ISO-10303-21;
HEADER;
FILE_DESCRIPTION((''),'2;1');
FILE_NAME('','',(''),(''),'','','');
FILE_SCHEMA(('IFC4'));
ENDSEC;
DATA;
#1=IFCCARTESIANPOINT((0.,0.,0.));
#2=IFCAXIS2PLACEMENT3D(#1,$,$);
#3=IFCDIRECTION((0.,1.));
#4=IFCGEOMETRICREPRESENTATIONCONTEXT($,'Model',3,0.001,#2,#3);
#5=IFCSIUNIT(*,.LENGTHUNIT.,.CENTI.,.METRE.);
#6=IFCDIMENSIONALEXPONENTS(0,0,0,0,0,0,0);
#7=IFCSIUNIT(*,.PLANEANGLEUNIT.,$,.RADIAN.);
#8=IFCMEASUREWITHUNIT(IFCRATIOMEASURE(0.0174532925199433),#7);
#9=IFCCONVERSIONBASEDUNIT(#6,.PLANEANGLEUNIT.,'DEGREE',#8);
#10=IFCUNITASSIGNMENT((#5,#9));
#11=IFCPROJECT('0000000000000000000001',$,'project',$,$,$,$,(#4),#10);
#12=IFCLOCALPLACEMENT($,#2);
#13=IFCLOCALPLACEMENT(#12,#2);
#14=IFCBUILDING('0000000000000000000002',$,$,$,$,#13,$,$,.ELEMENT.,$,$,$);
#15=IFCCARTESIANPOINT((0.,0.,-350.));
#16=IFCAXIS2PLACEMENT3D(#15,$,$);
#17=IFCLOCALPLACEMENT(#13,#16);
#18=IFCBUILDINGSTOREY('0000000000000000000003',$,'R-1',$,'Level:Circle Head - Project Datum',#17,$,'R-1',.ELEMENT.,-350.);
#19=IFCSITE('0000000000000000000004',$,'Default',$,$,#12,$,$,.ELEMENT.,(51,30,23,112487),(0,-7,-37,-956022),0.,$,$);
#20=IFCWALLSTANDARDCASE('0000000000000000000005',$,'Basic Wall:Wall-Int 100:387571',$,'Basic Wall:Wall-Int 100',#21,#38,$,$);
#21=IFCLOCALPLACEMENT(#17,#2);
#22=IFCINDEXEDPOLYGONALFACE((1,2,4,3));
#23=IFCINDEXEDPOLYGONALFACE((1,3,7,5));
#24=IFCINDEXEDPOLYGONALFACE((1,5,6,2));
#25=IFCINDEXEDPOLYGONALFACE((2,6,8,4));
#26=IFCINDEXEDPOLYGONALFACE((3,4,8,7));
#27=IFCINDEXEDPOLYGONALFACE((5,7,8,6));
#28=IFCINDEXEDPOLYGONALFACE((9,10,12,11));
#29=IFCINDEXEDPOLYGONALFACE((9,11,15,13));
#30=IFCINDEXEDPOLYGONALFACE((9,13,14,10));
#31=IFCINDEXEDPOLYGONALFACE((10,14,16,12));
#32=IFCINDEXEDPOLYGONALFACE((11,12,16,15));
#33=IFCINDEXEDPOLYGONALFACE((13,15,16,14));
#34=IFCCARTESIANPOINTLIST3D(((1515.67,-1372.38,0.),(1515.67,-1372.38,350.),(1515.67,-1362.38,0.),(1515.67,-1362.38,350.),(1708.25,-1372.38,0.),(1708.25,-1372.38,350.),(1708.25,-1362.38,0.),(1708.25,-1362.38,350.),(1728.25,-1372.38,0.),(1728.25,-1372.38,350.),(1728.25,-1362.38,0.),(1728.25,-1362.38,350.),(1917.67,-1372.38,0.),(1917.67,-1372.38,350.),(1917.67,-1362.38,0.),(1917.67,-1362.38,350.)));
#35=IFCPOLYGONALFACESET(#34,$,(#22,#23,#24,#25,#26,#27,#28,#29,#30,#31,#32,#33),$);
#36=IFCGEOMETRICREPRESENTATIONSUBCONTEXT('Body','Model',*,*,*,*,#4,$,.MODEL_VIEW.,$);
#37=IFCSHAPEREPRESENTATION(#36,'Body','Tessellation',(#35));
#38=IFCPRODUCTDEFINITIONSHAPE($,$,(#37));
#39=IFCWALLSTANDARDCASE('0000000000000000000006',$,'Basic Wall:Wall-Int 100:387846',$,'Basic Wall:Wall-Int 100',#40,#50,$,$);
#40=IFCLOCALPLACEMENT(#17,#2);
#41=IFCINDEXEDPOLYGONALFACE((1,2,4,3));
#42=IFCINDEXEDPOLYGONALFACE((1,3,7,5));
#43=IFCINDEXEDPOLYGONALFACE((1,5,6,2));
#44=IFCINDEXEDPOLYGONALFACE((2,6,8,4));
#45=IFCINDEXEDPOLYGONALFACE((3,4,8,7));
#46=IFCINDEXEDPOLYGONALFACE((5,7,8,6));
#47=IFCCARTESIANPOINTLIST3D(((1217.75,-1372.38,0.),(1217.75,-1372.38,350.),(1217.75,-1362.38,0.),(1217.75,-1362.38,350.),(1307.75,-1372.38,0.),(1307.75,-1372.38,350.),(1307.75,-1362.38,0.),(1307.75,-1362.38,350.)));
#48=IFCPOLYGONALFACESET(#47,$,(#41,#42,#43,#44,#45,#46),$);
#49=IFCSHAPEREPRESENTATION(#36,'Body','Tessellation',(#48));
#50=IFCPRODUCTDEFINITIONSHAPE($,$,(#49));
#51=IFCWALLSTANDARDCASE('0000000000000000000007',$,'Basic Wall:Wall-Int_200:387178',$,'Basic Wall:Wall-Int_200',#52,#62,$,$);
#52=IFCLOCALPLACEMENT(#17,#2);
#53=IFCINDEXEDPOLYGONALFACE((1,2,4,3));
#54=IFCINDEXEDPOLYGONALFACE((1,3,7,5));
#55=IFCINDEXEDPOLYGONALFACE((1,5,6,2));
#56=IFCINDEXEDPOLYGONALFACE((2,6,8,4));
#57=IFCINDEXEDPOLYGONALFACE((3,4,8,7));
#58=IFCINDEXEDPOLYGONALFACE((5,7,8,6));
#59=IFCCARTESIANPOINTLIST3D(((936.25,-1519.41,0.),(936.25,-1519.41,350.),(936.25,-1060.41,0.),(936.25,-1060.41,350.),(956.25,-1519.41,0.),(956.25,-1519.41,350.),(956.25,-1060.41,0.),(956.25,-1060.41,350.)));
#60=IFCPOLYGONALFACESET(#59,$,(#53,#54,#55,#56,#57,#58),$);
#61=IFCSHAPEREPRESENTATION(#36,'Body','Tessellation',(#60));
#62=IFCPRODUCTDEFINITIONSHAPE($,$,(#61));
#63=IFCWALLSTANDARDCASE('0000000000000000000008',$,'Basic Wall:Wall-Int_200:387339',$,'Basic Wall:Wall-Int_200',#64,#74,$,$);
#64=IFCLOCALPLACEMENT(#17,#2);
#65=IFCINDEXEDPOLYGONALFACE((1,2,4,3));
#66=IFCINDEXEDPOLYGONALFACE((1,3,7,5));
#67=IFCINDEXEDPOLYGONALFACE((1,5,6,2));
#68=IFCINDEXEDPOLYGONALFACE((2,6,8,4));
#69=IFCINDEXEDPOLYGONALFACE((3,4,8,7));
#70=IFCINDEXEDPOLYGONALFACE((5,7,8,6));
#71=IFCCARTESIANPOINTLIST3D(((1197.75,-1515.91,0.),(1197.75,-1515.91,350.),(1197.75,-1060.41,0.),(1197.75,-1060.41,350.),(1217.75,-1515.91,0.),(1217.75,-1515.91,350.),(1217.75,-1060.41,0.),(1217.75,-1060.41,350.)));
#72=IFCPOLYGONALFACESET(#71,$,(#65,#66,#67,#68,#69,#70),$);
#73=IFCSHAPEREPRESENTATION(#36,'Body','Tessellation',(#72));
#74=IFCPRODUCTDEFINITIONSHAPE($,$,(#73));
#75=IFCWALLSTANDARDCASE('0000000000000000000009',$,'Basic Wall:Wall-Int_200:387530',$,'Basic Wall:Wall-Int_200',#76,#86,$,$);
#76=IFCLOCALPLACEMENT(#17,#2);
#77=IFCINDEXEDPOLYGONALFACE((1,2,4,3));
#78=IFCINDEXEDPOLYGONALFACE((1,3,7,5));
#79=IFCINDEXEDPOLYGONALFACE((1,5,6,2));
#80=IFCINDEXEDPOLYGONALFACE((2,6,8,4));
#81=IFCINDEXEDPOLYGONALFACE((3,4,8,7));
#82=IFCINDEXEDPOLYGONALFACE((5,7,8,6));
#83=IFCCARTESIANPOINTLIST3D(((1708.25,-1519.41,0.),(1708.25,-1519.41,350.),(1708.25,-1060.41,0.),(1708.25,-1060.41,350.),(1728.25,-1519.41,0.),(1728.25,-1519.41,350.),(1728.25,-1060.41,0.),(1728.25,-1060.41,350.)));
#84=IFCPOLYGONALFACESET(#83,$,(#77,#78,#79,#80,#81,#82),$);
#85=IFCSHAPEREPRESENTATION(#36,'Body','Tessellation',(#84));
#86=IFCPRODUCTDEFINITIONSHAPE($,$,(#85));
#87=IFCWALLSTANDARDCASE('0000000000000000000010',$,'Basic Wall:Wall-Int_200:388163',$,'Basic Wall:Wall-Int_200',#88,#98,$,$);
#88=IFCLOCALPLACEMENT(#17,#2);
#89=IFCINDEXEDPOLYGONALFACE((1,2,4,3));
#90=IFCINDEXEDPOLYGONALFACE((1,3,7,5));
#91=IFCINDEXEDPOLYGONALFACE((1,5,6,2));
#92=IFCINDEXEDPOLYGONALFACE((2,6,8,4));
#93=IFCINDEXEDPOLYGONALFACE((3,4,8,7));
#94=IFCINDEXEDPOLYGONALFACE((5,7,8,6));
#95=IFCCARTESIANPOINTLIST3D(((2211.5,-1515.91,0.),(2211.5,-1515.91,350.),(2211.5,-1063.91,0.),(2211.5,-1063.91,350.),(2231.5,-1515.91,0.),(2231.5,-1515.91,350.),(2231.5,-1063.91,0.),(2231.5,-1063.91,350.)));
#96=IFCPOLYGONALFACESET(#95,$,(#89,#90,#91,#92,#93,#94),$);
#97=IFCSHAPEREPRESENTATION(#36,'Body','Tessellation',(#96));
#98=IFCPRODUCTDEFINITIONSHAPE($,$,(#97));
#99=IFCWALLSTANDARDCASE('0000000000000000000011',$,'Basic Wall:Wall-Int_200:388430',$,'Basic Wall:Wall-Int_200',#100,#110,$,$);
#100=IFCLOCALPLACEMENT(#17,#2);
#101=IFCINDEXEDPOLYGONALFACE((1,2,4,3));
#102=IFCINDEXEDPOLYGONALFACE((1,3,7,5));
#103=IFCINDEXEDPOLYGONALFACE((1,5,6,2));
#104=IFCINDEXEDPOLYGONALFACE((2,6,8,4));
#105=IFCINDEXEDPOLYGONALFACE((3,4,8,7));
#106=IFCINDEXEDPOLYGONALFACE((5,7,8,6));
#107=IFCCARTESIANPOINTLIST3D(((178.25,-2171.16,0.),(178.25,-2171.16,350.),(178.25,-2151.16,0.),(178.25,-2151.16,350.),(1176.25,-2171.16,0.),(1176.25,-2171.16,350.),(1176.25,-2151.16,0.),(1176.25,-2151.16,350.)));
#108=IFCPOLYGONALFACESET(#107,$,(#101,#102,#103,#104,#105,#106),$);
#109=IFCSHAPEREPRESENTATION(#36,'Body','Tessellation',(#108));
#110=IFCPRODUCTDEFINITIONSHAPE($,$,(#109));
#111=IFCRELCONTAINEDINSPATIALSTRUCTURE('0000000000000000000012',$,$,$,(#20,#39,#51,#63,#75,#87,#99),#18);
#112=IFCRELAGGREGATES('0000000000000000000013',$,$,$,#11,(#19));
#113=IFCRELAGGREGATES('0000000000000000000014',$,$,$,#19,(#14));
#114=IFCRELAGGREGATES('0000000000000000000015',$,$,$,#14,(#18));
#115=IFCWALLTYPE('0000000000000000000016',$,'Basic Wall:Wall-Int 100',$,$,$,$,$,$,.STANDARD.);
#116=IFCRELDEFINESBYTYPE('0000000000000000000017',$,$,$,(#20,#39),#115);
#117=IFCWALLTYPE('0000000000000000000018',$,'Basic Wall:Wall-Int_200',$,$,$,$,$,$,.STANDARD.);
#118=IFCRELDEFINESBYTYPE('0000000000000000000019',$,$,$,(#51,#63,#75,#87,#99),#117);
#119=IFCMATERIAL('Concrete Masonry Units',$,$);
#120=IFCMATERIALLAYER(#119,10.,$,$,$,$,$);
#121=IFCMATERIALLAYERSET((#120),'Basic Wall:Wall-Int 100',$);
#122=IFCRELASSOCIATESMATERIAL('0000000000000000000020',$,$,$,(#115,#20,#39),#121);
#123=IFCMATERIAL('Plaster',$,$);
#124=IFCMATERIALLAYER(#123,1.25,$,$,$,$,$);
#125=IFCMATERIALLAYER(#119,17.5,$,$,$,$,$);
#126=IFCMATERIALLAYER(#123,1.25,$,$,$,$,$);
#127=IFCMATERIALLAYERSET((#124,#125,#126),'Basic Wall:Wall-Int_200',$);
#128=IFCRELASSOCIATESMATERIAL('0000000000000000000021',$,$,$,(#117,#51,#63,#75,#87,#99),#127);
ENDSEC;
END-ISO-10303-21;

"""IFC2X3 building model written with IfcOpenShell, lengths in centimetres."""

from ifc_helpers import new_model, entity, si_unit, converted_unit, direction, frame, frame_2d, origin, place, context, subcontext, project, spatial, rectangle, extrude, material, layer, layer_set, layer_usage, type_object, element, save


model = new_model("IFC2X3")

# Units and contexts
model_context = context("Model", 3, precision=0.001, world=origin(), true_north=direction((0.0, 1.0)))
body_context = subcontext(model_context, "Body", "Model", "MODEL_VIEW")
ifc_project = project(units=[si_unit("LENGTHUNIT", "METRE", prefix="CENTI"), converted_unit("PLANEANGLEUNIT", "DEGREE", entity("IfcRatioMeasure", 0.0174532925199433), si_unit("PLANEANGLEUNIT", "RADIAN"), dimensions=[0, 0, 0, 0, 0, 0, 0])], contexts=[model_context])

# Site, building, storey
site_placement = place(None, origin())
site = spatial("IfcSite", under=ifc_project, at=site_placement, Name="Default", CompositionType="ELEMENT", RefLatitude=(51, 30, 23, 112487), RefLongitude=(0, -7, -37, -956022), RefElevation=0.0)
building_placement = place(site_placement, origin())
building = spatial("IfcBuilding", under=site, at=building_placement, CompositionType="ELEMENT")
storey_placement = place(building_placement, frame((0.0, 0.0, -350.0)))
storey = spatial("IfcBuildingStorey", under=building, at=storey_placement, Name="R-1", ObjectType="Level:Circle Head - Project Datum", LongName="R-1", CompositionType="ELEMENT", Elevation=-350.0)

# Shared definitions
ifc_material_1 = material(Name="Concrete Masonry Units")

# Wall, opening
ifc_layer_1 = layer(ifc_material_1, 10.0)
ifc_layer_set_1 = layer_set([ifc_layer_1], Name="Basic Wall:Wall-Int 100")
ifc_layer_usage_1 = layer_usage(ifc_layer_set_1, "AXIS2", "NEGATIVE", 5.0)
wall_type_1 = type_object("IfcWallType", Name="Basic Wall:Wall-Int 100", PredefinedType="STANDARD", material=ifc_layer_set_1)
wall_1_placement = place(storey_placement, frame((1917.67, -1367.38, 0.0), z_axis=(0.0, 0.0, 1.0), x_axis=(-1.0, 0.0, 0.0)))
wall_1 = element("IfcWallStandardCase", 1, at=wall_1_placement, inside=storey, type_object=wall_type_1, material=ifc_layer_usage_1, Name="Basic Wall:Wall-Int 100:387571", ObjectType="Basic Wall:Wall-Int 100", context=body_context, shape_type="SweptSolid", body=[
    extrude(rectangle(XDim=402.0, YDim=10.0, at=frame_2d((201.0, 0.0), x_axis=(-1.0, 0.0))), origin(), (0.0, 0.0, 1.0), 350.0),
])
opening_1_placement = place(storey_placement, frame((1917.67, -1367.38, 0.0), z_axis=(0.0, 0.0, 1.0), x_axis=(-1.0, 0.0, 0.0)))
element("IfcOpeningElement", 2, at=opening_1_placement, cuts=wall_1, ObjectType="Opening", context=body_context, shape_type="SweptSolid", body=[
    extrude(rectangle(XDim=350.0, YDim=10.0, at=frame_2d((0.0, 0.0), x_axis=(1.0, 0.0))), frame((209.43, 0.0, 175.0), z_axis=(-1.0, 0.0, 0.0), x_axis=(0.0, 0.0, 1.0)), (0.0, 0.0, 1.0), 20.0),
])

# Walls
ifc_layer_usage_2 = layer_usage(ifc_layer_set_1, "AXIS2", "NEGATIVE", 5.0)
wall_2_placement = place(storey_placement, frame((1217.75, -1367.38, 0.0)))
element("IfcWallStandardCase", 3, at=wall_2_placement, inside=storey, type_object=wall_type_1, material=ifc_layer_usage_2, Name="Basic Wall:Wall-Int 100:387846", ObjectType="Basic Wall:Wall-Int 100", context=body_context, shape_type="SweptSolid", body=[
    extrude(rectangle(XDim=90.0, YDim=10.0, at=frame_2d((45.0, 0.0), x_axis=(-1.0, 0.0))), origin(), (0.0, 0.0, 1.0), 350.0),
])
ifc_material_2 = material(Name="Plaster")
ifc_layer_2 = layer(ifc_material_2, 1.25)
ifc_layer_3 = layer(ifc_material_1, 17.5)
ifc_layer_4 = layer(ifc_material_2, 1.25)
ifc_layer_set_2 = layer_set([ifc_layer_2, ifc_layer_3, ifc_layer_4], Name="Basic Wall:Wall-Int_200")
ifc_layer_usage_3 = layer_usage(ifc_layer_set_2, "AXIS2", "NEGATIVE", 10.0)
wall_type_2 = type_object("IfcWallType", Name="Basic Wall:Wall-Int_200", PredefinedType="STANDARD", material=ifc_layer_set_2)
wall_3_placement = place(storey_placement, frame((946.25, -1519.41, 0.0), z_axis=(0.0, 0.0, 1.0), x_axis=(0.0, 1.0, 0.0)))
element("IfcWallStandardCase", 4, at=wall_3_placement, inside=storey, type_object=wall_type_2, material=ifc_layer_usage_3, Name="Basic Wall:Wall-Int_200:387178", ObjectType="Basic Wall:Wall-Int_200", context=body_context, shape_type="SweptSolid", body=[
    extrude(rectangle(XDim=459.0, YDim=20.0, at=frame_2d((229.5, 0.0), x_axis=(-1.0, 0.0))), origin(), (0.0, 0.0, 1.0), 350.0),
])
ifc_layer_usage_4 = layer_usage(ifc_layer_set_2, "AXIS2", "POSITIVE", -10.0)
wall_4_placement = place(storey_placement, frame((1207.75, -1515.91, 0.0), z_axis=(0.0, 0.0, 1.0), x_axis=(0.0, 1.0, 0.0)))
element("IfcWallStandardCase", 5, at=wall_4_placement, inside=storey, type_object=wall_type_2, material=ifc_layer_usage_4, Name="Basic Wall:Wall-Int_200:387339", ObjectType="Basic Wall:Wall-Int_200", context=body_context, shape_type="SweptSolid", body=[
    extrude(rectangle(XDim=455.5, YDim=20.0, at=frame_2d((227.75, 0.0), x_axis=(-1.0, 0.0))), origin(), (0.0, 0.0, 1.0), 350.0),
])
ifc_layer_usage_5 = layer_usage(ifc_layer_set_2, "AXIS2", "NEGATIVE", 10.0)
wall_5_placement = place(storey_placement, frame((1718.25, -1519.41, 0.0), z_axis=(0.0, 0.0, 1.0), x_axis=(0.0, 1.0, 0.0)))
element("IfcWallStandardCase", 6, at=wall_5_placement, inside=storey, type_object=wall_type_2, material=ifc_layer_usage_5, Name="Basic Wall:Wall-Int_200:387530", ObjectType="Basic Wall:Wall-Int_200", context=body_context, shape_type="SweptSolid", body=[
    extrude(rectangle(XDim=459.0, YDim=20.0, at=frame_2d((229.5, 0.0), x_axis=(-1.0, 0.0))), origin(), (0.0, 0.0, 1.0), 350.0),
])
ifc_layer_usage_6 = layer_usage(ifc_layer_set_2, "AXIS2", "NEGATIVE", 10.0)
wall_6_placement = place(storey_placement, frame((2221.5, -1515.91, 0.0), z_axis=(0.0, 0.0, 1.0), x_axis=(0.0, 1.0, 0.0)))
element("IfcWallStandardCase", 7, at=wall_6_placement, inside=storey, type_object=wall_type_2, material=ifc_layer_usage_6, Name="Basic Wall:Wall-Int_200:388163", ObjectType="Basic Wall:Wall-Int_200", context=body_context, shape_type="SweptSolid", body=[
    extrude(rectangle(XDim=452.0, YDim=20.0, at=frame_2d((226.0, 0.0), x_axis=(-1.0, 0.0))), origin(), (0.0, 0.0, 1.0), 350.0),
])
ifc_layer_usage_7 = layer_usage(ifc_layer_set_2, "AXIS2", "POSITIVE", -10.0)
wall_7_placement = place(storey_placement, frame((1176.25, -2161.16, 0.0), z_axis=(0.0, 0.0, 1.0), x_axis=(-1.0, 0.0, 0.0)))
element("IfcWallStandardCase", 8, at=wall_7_placement, inside=storey, type_object=wall_type_2, material=ifc_layer_usage_7, Name="Basic Wall:Wall-Int_200:388430", ObjectType="Basic Wall:Wall-Int_200", context=body_context, shape_type="SweptSolid", body=[
    extrude(rectangle(XDim=998.0, YDim=20.0, at=frame_2d((499.0, 0.0), x_axis=(-1.0, 0.0))), origin(), (0.0, 0.0, 1.0), 350.0),
])

save(model, "model.ifc")
